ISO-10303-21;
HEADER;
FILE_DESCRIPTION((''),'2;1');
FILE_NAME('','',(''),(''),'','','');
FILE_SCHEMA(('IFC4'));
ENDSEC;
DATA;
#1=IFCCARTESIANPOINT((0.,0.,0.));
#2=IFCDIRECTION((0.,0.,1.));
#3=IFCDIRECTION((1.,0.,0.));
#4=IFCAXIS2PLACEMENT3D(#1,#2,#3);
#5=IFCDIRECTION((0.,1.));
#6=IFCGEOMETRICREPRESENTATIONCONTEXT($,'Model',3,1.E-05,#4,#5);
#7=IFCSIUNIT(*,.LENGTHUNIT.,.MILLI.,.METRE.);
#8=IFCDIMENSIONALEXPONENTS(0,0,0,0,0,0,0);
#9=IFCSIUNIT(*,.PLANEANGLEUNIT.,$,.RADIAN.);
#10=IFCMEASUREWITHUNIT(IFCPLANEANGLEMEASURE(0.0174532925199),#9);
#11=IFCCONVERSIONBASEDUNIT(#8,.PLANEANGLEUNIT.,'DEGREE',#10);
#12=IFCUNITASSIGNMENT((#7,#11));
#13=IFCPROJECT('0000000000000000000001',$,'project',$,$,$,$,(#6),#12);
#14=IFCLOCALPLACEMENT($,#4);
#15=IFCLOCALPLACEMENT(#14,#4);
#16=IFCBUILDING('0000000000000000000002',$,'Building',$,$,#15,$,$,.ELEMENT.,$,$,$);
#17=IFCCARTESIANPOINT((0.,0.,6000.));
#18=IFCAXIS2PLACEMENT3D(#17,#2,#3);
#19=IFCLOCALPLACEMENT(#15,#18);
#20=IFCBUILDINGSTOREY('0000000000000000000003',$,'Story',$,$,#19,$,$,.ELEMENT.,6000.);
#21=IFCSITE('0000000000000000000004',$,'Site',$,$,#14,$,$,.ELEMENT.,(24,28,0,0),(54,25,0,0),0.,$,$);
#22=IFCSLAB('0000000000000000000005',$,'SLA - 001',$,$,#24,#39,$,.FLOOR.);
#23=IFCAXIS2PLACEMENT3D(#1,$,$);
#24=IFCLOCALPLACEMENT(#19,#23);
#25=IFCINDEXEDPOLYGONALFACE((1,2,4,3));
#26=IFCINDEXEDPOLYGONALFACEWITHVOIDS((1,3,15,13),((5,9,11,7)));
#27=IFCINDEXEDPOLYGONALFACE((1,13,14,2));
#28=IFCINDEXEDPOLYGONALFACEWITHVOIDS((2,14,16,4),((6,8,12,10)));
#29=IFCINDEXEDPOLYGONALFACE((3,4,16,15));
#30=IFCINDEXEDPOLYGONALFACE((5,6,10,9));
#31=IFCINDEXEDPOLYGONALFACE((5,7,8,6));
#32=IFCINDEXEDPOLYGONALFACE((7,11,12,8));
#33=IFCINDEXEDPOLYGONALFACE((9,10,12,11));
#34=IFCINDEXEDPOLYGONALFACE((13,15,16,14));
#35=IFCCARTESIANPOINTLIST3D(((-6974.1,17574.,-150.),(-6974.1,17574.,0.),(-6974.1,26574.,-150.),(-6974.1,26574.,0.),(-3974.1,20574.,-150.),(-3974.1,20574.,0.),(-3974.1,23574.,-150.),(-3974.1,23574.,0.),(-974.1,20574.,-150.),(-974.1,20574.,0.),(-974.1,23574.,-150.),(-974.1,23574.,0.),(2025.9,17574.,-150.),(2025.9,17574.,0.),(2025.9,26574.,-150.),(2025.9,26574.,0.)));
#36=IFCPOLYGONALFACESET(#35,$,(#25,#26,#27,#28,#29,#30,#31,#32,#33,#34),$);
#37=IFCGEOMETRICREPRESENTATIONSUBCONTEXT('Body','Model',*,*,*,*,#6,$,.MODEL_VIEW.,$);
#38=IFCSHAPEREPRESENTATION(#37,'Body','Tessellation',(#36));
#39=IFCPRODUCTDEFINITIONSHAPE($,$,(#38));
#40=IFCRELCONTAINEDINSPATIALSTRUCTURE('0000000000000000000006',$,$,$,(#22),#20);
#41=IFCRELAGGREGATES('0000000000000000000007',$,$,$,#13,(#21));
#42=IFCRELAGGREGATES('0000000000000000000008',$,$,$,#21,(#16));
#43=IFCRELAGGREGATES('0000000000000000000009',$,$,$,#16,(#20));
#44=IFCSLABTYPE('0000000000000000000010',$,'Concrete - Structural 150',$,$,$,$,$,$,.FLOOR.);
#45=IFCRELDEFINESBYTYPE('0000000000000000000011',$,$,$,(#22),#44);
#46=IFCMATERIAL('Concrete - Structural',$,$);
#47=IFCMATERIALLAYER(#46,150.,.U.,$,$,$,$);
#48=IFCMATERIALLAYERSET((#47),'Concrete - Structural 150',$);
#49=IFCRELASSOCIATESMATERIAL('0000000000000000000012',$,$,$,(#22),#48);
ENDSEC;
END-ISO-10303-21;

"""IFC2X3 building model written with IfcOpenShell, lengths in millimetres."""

from ifc_helpers import new_model, entity, si_unit, converted_unit, direction, frame, origin_with_axes, place, context, subcontext, project, spatial, polyline, outline, extrude, material, layer, layer_set, layer_usage, type_object, element, save


model = new_model("IFC2X3")

# Units and contexts
model_context = context("Model", 3, precision=1e-05, world=origin_with_axes(), true_north=direction((0.0, 1.0)))
body_context = subcontext(model_context, "Body", "Model", "MODEL_VIEW")
ifc_project = project(units=[si_unit("LENGTHUNIT", "METRE", prefix="MILLI"), converted_unit("PLANEANGLEUNIT", "DEGREE", entity("IfcPlaneAngleMeasure", 0.0174532925199), si_unit("PLANEANGLEUNIT", "RADIAN"), dimensions=[0, 0, 0, 0, 0, 0, 0])], contexts=[model_context])

# Site, building, storey
site_placement = place(None, origin_with_axes())
site = spatial("IfcSite", under=ifc_project, at=site_placement, Name="Site", CompositionType="ELEMENT", RefLatitude=(24, 28, 0, 0), RefLongitude=(54, 25, 0, 0), RefElevation=0.0)
building_placement = place(site_placement, origin_with_axes())
building = spatial("IfcBuilding", under=site, at=building_placement, Name="Building", CompositionType="ELEMENT")
storey_placement = place(building_placement, frame((0.0, 0.0, 6000.0), z_axis=(0.0, 0.0, 1.0), x_axis=(1.0, 0.0, 0.0)))
storey = spatial("IfcBuildingStorey", under=building, at=storey_placement, Name="Story", CompositionType="ELEMENT", Elevation=6000.0)

# Slab, opening
ifc_material = material(Name="Concrete - Structural")
ifc_layer = layer(ifc_material, 150.0, ventilated="UNKNOWN")
ifc_layer_set = layer_set([ifc_layer], Name="Concrete - Structural 150")
ifc_layer_usage = layer_usage(ifc_layer_set, "AXIS3", "NEGATIVE", 150.0)
slab_type = type_object("IfcSlabType", Name="Concrete - Structural 150", PredefinedType="FLOOR")
slab_placement = place(storey_placement, frame((-6974.1, 26574.0, 0.0), z_axis=(0.0, 0.0, 1.0), x_axis=(1.0, 0.0, 0.0)))
slab = element("IfcSlab", 1, at=slab_placement, inside=storey, type_object=slab_type, material=ifc_layer_usage, Name="SLA - 001", PredefinedType="FLOOR", context=body_context, shape_type="SweptSolid", body=[
    extrude(outline(polyline([(0.0, 0.0), (0.0, -9000.0), (9000.0, -9000.0), (9000.0, 0.0), (0.0, 0.0)])), frame((0.0, 0.0, -150.0), z_axis=(0.0, 0.0, 1.0), x_axis=(1.0, 0.0, 0.0)), (0.0, 0.0, 1.0), 150.0),
])
opening_placement = place(slab_placement, origin_with_axes())
element("IfcOpeningElement", 2, at=opening_placement, cuts=slab, context=body_context, shape_type="SweptSolid", body=[
    extrude(outline(polyline([(3000.0, -3000.0), (3000.0, -6000.0), (6000.0, -6000.0), (6000.0, -3000.0), (3000.0, -3000.0)])), frame((0.0, 0.0, -150.0), z_axis=(0.0, 0.0, 1.0), x_axis=(1.0, 0.0, 0.0)), (0.0, 0.0, 1.0), 150.0),
])

save(model, "model.ifc")
